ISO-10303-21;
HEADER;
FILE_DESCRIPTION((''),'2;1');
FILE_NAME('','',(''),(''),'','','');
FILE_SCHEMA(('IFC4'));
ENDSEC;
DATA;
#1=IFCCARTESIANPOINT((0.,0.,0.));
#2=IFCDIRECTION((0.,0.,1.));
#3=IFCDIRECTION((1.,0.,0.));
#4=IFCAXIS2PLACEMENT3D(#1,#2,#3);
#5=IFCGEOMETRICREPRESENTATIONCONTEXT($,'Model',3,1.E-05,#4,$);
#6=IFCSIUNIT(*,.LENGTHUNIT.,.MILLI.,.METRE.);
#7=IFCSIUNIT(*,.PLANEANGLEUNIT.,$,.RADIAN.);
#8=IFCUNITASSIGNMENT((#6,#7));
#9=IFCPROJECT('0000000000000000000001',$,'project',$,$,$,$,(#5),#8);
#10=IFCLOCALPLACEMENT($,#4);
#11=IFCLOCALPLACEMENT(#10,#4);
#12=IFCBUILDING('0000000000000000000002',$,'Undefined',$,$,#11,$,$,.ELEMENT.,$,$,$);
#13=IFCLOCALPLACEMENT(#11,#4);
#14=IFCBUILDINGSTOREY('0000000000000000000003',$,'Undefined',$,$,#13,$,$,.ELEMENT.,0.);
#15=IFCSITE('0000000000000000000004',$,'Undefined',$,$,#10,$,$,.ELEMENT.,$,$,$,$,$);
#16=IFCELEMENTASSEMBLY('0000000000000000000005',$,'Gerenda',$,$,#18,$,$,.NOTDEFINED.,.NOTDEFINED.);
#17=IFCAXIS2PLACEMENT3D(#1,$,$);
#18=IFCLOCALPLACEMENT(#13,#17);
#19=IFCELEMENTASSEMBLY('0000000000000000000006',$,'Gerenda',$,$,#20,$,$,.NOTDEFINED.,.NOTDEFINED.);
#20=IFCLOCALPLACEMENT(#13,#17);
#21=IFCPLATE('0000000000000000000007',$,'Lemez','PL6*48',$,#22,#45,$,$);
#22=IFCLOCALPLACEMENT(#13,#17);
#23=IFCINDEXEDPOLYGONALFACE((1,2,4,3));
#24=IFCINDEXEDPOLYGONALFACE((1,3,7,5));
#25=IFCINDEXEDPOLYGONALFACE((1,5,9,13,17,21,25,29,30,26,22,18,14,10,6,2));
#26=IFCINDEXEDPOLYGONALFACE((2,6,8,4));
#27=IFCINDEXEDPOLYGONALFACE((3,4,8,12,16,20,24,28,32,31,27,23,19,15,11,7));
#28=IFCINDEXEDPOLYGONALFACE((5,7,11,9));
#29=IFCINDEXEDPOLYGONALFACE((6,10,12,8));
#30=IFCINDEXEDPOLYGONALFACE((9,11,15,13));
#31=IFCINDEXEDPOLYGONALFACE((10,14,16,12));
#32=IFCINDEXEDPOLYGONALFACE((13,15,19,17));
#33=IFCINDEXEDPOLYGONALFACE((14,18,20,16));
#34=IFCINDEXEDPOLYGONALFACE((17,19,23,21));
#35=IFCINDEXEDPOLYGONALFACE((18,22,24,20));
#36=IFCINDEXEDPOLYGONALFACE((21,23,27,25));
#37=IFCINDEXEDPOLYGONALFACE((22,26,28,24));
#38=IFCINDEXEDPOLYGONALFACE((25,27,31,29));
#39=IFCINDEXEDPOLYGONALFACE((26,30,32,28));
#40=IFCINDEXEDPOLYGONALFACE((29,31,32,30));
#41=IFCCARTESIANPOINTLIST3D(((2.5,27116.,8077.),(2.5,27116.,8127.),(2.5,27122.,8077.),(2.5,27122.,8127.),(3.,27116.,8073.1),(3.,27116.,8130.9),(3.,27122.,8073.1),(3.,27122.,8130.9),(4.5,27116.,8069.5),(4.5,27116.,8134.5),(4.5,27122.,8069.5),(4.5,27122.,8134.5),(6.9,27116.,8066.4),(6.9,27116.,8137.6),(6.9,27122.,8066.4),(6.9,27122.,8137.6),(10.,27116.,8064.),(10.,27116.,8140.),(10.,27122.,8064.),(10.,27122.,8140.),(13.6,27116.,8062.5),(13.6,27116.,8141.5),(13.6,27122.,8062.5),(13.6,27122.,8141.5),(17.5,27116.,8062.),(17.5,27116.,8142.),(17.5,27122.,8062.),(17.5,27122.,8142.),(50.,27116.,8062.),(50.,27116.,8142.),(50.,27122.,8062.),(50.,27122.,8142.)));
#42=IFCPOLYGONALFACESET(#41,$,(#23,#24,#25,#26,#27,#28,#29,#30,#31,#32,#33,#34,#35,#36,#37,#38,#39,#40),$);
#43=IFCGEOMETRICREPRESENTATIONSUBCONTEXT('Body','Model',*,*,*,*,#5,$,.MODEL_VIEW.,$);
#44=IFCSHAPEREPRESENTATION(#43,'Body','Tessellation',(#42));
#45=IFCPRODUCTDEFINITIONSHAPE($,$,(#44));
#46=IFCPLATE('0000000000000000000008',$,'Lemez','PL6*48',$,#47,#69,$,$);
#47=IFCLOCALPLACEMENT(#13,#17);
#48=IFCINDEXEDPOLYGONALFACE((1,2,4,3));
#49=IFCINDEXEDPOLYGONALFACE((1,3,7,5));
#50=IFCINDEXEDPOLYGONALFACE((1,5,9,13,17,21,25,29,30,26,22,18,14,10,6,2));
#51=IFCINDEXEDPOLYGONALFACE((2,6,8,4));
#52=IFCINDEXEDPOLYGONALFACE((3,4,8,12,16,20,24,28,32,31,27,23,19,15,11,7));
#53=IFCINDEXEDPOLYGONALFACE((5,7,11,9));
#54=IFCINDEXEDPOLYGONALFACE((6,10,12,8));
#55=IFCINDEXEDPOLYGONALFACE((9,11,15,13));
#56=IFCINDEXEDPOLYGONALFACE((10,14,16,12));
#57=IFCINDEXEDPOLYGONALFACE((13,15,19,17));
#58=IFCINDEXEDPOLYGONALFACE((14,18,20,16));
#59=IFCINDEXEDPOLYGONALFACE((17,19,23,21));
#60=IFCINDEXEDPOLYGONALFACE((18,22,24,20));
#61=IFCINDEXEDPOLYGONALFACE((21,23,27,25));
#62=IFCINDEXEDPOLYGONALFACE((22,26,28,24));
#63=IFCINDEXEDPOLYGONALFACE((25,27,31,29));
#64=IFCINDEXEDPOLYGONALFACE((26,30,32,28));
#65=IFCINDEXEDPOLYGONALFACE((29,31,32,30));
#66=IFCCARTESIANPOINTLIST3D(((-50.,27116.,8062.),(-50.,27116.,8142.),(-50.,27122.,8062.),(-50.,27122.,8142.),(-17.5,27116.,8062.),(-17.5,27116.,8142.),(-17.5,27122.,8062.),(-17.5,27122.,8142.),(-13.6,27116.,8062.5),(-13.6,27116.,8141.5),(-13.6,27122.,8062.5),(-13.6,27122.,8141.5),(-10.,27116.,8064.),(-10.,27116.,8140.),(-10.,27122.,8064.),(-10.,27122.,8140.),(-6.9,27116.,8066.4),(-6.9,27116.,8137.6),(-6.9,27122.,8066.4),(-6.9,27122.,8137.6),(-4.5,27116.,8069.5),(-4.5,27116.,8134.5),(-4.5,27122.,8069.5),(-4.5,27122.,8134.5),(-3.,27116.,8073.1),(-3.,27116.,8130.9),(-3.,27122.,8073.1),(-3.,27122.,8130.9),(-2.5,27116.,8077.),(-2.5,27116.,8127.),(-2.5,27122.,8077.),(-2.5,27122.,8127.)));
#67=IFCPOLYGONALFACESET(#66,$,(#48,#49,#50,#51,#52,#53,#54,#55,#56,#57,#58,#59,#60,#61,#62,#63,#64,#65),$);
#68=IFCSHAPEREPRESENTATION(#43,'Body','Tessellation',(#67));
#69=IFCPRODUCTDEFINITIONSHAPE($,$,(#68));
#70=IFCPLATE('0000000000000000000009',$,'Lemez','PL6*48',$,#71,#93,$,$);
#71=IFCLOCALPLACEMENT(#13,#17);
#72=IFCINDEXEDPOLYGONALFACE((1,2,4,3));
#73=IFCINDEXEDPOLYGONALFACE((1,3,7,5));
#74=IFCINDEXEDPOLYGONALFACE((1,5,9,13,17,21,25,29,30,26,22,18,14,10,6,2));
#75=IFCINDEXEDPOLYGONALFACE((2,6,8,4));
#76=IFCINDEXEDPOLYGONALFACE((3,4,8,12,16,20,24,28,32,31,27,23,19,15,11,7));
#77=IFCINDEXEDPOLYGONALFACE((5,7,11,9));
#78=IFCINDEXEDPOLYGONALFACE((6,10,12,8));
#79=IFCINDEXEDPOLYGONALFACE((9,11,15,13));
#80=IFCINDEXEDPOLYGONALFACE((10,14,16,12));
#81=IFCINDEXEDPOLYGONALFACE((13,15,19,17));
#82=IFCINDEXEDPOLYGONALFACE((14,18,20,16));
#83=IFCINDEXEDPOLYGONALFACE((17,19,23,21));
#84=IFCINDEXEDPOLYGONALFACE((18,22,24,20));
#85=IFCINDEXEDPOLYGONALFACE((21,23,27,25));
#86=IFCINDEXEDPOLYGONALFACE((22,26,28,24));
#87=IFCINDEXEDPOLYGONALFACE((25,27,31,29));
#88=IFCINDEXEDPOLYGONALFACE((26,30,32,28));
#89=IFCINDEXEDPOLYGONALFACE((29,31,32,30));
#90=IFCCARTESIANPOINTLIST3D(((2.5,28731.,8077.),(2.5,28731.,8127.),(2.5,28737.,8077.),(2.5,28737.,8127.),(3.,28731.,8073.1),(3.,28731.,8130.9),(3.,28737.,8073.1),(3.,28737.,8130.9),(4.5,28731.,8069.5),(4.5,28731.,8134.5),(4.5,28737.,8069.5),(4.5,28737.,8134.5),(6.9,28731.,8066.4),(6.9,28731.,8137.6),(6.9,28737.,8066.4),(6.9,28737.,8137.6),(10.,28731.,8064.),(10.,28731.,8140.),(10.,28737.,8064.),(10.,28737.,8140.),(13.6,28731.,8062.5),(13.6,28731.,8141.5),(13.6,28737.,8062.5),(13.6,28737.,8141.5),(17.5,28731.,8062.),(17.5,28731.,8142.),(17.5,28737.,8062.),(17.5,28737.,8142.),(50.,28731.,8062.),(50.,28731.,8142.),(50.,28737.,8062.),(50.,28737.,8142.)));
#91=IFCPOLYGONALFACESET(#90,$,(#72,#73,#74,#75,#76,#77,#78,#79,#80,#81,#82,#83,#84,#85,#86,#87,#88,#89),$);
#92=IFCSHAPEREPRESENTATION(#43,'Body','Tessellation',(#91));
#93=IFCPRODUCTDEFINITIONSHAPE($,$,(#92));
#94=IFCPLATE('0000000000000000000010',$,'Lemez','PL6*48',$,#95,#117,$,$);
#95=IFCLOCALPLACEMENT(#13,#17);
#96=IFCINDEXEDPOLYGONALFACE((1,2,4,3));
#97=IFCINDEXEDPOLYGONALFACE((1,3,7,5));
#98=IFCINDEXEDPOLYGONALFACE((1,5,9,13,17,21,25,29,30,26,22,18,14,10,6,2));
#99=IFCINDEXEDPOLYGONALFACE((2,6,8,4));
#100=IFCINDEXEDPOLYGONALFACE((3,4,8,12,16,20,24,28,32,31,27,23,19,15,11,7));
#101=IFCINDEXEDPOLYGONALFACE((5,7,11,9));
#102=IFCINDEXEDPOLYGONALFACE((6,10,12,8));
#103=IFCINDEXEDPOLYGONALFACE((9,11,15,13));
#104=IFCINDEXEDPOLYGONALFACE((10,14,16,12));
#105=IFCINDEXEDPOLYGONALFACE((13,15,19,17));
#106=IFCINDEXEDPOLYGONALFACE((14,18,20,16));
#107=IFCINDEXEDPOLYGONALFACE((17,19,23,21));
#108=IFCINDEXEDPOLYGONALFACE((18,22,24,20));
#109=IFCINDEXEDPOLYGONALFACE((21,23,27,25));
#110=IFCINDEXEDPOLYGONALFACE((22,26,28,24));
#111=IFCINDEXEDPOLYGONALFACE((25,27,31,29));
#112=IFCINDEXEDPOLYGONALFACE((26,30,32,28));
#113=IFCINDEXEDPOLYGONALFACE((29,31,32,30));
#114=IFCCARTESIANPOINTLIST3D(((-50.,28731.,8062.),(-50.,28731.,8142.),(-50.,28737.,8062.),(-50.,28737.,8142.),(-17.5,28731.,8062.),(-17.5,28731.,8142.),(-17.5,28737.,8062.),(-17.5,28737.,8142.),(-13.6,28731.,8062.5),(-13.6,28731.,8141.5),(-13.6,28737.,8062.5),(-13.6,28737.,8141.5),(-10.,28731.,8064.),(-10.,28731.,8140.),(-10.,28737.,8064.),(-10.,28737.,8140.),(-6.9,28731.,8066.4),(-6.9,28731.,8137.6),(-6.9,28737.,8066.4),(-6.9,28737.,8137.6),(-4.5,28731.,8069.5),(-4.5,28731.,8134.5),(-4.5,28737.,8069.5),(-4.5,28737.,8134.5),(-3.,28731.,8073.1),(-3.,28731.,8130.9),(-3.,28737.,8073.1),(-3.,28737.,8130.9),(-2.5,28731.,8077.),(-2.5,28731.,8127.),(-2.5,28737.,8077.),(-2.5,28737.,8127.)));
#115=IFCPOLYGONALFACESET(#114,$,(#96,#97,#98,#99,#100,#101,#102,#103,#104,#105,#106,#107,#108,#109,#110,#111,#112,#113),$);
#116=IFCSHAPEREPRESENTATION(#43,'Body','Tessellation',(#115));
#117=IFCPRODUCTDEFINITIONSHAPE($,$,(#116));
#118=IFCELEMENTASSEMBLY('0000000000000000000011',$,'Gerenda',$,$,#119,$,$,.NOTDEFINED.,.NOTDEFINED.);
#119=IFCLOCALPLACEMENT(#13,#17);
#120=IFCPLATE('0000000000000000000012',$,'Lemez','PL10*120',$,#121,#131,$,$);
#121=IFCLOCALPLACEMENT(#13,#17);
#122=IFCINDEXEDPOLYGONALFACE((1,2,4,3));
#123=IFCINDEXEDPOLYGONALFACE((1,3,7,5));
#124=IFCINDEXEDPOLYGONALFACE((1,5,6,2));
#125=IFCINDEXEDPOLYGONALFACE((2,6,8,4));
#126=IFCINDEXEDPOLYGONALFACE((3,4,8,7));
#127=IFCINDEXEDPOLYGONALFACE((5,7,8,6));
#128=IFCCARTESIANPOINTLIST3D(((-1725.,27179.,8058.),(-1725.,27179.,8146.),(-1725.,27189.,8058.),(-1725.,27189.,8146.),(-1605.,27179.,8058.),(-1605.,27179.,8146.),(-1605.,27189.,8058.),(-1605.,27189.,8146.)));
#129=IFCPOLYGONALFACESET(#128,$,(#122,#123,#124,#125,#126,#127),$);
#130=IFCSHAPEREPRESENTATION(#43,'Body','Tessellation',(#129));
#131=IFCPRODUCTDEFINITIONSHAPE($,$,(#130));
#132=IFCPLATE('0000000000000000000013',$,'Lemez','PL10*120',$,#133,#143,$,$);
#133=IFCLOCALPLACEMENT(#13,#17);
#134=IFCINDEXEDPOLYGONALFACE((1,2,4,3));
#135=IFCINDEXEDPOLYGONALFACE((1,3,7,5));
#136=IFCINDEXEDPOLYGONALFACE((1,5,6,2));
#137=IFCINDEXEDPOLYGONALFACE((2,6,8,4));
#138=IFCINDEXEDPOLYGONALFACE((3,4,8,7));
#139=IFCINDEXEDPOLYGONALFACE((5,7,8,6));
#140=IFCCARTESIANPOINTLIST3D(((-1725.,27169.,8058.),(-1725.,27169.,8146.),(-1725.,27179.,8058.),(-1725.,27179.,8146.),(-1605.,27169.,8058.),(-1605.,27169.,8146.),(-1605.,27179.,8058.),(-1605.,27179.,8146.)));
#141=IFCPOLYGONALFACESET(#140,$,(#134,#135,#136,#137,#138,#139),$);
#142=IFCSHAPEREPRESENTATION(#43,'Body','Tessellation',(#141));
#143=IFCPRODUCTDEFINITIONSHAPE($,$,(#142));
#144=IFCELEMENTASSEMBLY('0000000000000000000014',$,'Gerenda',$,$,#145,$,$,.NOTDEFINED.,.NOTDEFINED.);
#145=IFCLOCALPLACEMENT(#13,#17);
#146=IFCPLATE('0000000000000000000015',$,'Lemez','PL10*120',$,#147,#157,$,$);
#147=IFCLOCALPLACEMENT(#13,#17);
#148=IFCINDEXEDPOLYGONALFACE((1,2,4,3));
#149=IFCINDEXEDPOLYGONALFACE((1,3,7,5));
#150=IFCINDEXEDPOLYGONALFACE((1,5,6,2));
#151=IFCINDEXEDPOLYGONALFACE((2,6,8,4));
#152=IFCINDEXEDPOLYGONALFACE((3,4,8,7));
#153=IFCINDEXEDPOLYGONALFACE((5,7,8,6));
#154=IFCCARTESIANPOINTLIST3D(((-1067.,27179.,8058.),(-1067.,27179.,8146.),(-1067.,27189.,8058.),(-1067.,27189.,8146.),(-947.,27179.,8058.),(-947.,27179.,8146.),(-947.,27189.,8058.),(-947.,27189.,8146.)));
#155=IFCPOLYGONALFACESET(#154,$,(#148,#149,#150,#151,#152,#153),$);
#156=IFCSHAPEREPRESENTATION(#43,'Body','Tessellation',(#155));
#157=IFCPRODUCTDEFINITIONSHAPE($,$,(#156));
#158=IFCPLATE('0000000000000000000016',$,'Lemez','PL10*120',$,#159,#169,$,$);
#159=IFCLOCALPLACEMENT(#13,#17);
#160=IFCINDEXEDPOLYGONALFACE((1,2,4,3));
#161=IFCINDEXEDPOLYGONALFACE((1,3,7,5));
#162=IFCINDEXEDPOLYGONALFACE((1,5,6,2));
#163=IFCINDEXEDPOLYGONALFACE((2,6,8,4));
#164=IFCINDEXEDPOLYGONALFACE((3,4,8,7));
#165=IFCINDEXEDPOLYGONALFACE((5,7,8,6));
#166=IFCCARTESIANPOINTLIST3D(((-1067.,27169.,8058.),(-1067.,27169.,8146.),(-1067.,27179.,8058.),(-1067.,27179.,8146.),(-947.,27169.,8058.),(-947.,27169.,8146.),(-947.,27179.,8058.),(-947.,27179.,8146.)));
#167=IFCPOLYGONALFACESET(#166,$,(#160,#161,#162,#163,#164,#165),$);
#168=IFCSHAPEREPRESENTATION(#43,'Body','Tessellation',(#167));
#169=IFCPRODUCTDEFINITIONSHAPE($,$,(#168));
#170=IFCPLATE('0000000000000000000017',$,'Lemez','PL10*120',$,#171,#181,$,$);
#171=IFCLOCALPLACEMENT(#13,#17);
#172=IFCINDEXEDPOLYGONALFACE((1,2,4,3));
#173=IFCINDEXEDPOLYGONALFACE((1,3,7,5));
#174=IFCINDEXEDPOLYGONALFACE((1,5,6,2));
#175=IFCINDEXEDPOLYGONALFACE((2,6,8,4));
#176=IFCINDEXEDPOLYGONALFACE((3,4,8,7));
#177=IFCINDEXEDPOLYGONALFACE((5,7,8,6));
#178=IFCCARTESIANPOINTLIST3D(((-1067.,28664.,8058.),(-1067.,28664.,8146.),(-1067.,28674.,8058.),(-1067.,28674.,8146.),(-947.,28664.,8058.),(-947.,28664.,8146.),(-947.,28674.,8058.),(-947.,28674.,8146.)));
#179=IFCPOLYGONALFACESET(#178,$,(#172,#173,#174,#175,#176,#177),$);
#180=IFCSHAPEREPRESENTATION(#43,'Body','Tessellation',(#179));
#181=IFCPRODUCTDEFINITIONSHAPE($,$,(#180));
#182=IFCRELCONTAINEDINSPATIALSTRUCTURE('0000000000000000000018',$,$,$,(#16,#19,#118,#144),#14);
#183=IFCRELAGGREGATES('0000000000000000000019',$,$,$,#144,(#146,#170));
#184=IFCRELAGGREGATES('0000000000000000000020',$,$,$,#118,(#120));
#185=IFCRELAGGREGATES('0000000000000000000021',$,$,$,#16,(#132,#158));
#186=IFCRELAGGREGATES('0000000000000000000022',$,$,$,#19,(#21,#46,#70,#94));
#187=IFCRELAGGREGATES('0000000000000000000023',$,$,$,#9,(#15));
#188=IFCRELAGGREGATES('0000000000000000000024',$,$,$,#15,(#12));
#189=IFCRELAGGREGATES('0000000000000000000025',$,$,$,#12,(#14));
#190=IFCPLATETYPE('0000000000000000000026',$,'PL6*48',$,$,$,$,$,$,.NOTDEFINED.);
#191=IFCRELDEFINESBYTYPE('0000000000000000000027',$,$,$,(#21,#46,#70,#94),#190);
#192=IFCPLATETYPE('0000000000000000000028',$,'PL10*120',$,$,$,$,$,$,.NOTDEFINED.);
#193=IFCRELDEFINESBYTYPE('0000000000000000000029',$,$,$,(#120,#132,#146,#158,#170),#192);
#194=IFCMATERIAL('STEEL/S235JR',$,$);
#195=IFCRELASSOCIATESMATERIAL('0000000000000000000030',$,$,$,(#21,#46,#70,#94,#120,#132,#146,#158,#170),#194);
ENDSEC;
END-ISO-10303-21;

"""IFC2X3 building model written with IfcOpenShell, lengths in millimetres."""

from ifc_helpers import new_model, si_unit, frame, frame_2d, origin_with_axes, place, context, subcontext, project, spatial, polyline, circle_curve, parameter, trimmed, segment, composite_curve, outline, extrude, material, type_object, element, aggregate, save


model = new_model("IFC2X3")

# Units and contexts
model_context = context("Model", 3, precision=1e-05, world=origin_with_axes())
body_context = subcontext(model_context, "Body", "Model", "MODEL_VIEW")
ifc_project = project(units=[si_unit("LENGTHUNIT", "METRE", prefix="MILLI"), si_unit("PLANEANGLEUNIT", "RADIAN")], contexts=[model_context])

# Site, building, storey
site_placement = place(None, origin_with_axes())
site = spatial("IfcSite", under=ifc_project, at=site_placement, Name="Undefined", CompositionType="ELEMENT")
building_placement = place(site_placement, origin_with_axes())
building = spatial("IfcBuilding", under=site, at=building_placement, Name="Undefined", CompositionType="ELEMENT")
storey_placement = place(building_placement, origin_with_axes())
storey = spatial("IfcBuildingStorey", under=building, at=storey_placement, Name="Undefined", CompositionType="ELEMENT", Elevation=0.0)

# Element assemblies, plates
assembly_1_placement = place(storey_placement, origin_with_axes())
assembly_1 = element("IfcElementAssembly", 1, at=assembly_1_placement, inside=storey, Name="Gerenda", AssemblyPlace="NOTDEFINED", PredefinedType="NOTDEFINED")
ifc_material = material(Name="STEEL/S235JR")
plate_type_1 = type_object("IfcPlateType", Name="PL6*48", PredefinedType="NOTDEFINED")
assembly_2_placement = place(storey_placement, origin_with_axes())
assembly_2 = element("IfcElementAssembly", 2, at=assembly_2_placement, inside=storey, Name="Gerenda", AssemblyPlace="NOTDEFINED", PredefinedType="NOTDEFINED")
plate_1_placement = place(assembly_2_placement, frame((2.5, 27119.0, 8062.0), z_axis=(-0.000003, -1.0, 0.0), x_axis=(1.0, -0.000003, 0.0)))
plate_1 = element("IfcPlate", 3, at=plate_1_placement, type_object=plate_type_1, material=ifc_material, Name="Lemez", Description="PL6*48", context=body_context, shape_type="SweptSolid", body=[
    extrude(outline(composite_curve([segment(trimmed(circle_curve(frame_2d((15.0, 15.0), x_axis=(-1.0, 0.0)), 15.0), [parameter(0.0)], [parameter(1.570796)], True, "PARAMETER"), True, "CONTINUOUS"), segment(polyline([(15.0, 0.0), (47.5, 0.0), (47.5, 80.0), (15.0, 80.0)]), True, "CONTINUOUS"), segment(trimmed(circle_curve(frame_2d((15.0, 65.0), x_axis=(0.0, 1.0)), 15.0), [parameter(0.0)], [parameter(1.570796)], True, "PARAMETER"), True, "CONTINUOUS"), segment(polyline([(0.0, 65.0), (0.0, 15.0)]), True, "CONTINUOUS")], self_intersect=True)), frame((0.0, 0.0, -3.0), z_axis=(0.0, 0.0, 1.0), x_axis=(1.0, 0.0, 0.0)), (0.0, 0.0, 1.0), 6.0),
])
plate_2_placement = place(assembly_2_placement, frame((-2.5, 27119.0, 8062.0), z_axis=(0.000003, 1.0, 0.0), x_axis=(-1.0, 0.000003, 0.0)))
plate_2 = element("IfcPlate", 4, at=plate_2_placement, type_object=plate_type_1, material=ifc_material, Name="Lemez", Description="PL6*48", context=body_context, shape_type="SweptSolid", body=[
    extrude(outline(composite_curve([segment(trimmed(circle_curve(frame_2d((15.0, 15.0), x_axis=(-1.0, 0.0)), 15.0), [parameter(0.0)], [parameter(1.570796)], True, "PARAMETER"), True, "CONTINUOUS"), segment(polyline([(15.0, 0.0), (47.5, 0.0), (47.5, 80.0), (15.0, 80.0)]), True, "CONTINUOUS"), segment(trimmed(circle_curve(frame_2d((15.0, 65.0), x_axis=(0.0, 1.0)), 15.0), [parameter(0.0)], [parameter(1.570796)], True, "PARAMETER"), True, "CONTINUOUS"), segment(polyline([(0.0, 65.0), (0.0, 15.0)]), True, "CONTINUOUS")], self_intersect=True)), frame((0.0, 0.0, -3.0), z_axis=(0.0, 0.0, 1.0), x_axis=(1.0, 0.0, 0.0)), (0.0, 0.0, 1.0), 6.0),
])
plate_3_placement = place(assembly_2_placement, frame((2.5, 28734.0, 8062.0), z_axis=(-0.000003, -1.0, 0.0), x_axis=(1.0, -0.000003, 0.0)))
plate_3 = element("IfcPlate", 5, at=plate_3_placement, type_object=plate_type_1, material=ifc_material, Name="Lemez", Description="PL6*48", context=body_context, shape_type="SweptSolid", body=[
    extrude(outline(composite_curve([segment(trimmed(circle_curve(frame_2d((15.0, 15.0), x_axis=(-1.0, 0.0)), 15.0), [parameter(0.0)], [parameter(1.570796)], True, "PARAMETER"), True, "CONTINUOUS"), segment(polyline([(15.0, 0.0), (47.5, 0.0), (47.5, 80.0), (15.0, 80.0)]), True, "CONTINUOUS"), segment(trimmed(circle_curve(frame_2d((15.0, 65.0), x_axis=(0.0, 1.0)), 15.0), [parameter(0.0)], [parameter(1.570796)], True, "PARAMETER"), True, "CONTINUOUS"), segment(polyline([(0.0, 65.0), (0.0, 15.0)]), True, "CONTINUOUS")], self_intersect=True)), frame((0.0, 0.0, -3.0), z_axis=(0.0, 0.0, 1.0), x_axis=(1.0, 0.0, 0.0)), (0.0, 0.0, 1.0), 6.0),
])
plate_4_placement = place(assembly_2_placement, frame((-2.5, 28734.0, 8062.0), z_axis=(0.000003, 1.0, 0.0), x_axis=(-1.0, 0.000003, 0.0)))
plate_4 = element("IfcPlate", 6, at=plate_4_placement, type_object=plate_type_1, material=ifc_material, Name="Lemez", Description="PL6*48", context=body_context, shape_type="SweptSolid", body=[
    extrude(outline(composite_curve([segment(trimmed(circle_curve(frame_2d((15.0, 15.0), x_axis=(-1.0, 0.0)), 15.0), [parameter(0.0)], [parameter(1.570796)], True, "PARAMETER"), True, "CONTINUOUS"), segment(polyline([(15.0, 0.0), (47.5, 0.0), (47.5, 80.0), (15.0, 80.0)]), True, "CONTINUOUS"), segment(trimmed(circle_curve(frame_2d((15.0, 65.0), x_axis=(0.0, 1.0)), 15.0), [parameter(0.0)], [parameter(1.570796)], True, "PARAMETER"), True, "CONTINUOUS"), segment(polyline([(0.0, 65.0), (0.0, 15.0)]), True, "CONTINUOUS")], self_intersect=True)), frame((0.0, 0.0, -3.0), z_axis=(0.0, 0.0, 1.0), x_axis=(1.0, 0.0, 0.0)), (0.0, 0.0, 1.0), 6.0),
])

# Element assembly, plate
assembly_3_placement = place(storey_placement, origin_with_axes())
assembly_3 = element("IfcElementAssembly", 7, at=assembly_3_placement, inside=storey, Name="Gerenda", AssemblyPlace="NOTDEFINED", PredefinedType="NOTDEFINED")
plate_type_2 = type_object("IfcPlateType", Name="PL10*120", PredefinedType="NOTDEFINED")
plate_5_placement = place(assembly_3_placement, frame((-1665.0, 27184.0, 8058.0), z_axis=(0.000003, 1.0, 0.0), x_axis=(0.0, 0.0, 1.0)))
plate_5 = element("IfcPlate", 8, at=plate_5_placement, type_object=plate_type_2, material=ifc_material, Name="Lemez", Description="PL10*120", context=body_context, shape_type="SweptSolid", body=[
    extrude(outline(polyline([(0.0, -60.0), (0.0, 60.0), (88.0, 60.0), (88.0, -60.0), (0.0, -60.0)])), frame((0.0, 0.0, -5.0), z_axis=(0.0, 0.0, 1.0), x_axis=(1.0, 0.0, 0.0)), (0.0, 0.0, 1.0), 10.0),
])

# Plate
plate_6_placement = place(assembly_1_placement, frame((-1665.0, 27174.0, 8058.0), z_axis=(0.000003, 1.0, 0.0), x_axis=(0.0, 0.0, 1.0)))
plate_6 = element("IfcPlate", 9, at=plate_6_placement, type_object=plate_type_2, material=ifc_material, Name="Lemez", Description="PL10*120", context=body_context, shape_type="SweptSolid", body=[
    extrude(outline(polyline([(0.0, -60.0), (0.0, 60.0), (88.0, 60.0), (88.0, -60.0), (0.0, -60.0)])), frame((0.0, 0.0, -5.0), z_axis=(0.0, 0.0, 1.0), x_axis=(1.0, 0.0, 0.0)), (0.0, 0.0, 1.0), 10.0),
])

# Element assembly, plate
assembly_4_placement = place(storey_placement, origin_with_axes())
assembly_4 = element("IfcElementAssembly", 10, at=assembly_4_placement, inside=storey, Name="Gerenda", AssemblyPlace="NOTDEFINED", PredefinedType="NOTDEFINED")
plate_7_placement = place(assembly_4_placement, frame((-1007.0, 27184.0, 8058.0), z_axis=(0.000003, 1.0, 0.0), x_axis=(0.0, 0.0, 1.0)))
plate_7 = element("IfcPlate", 11, at=plate_7_placement, type_object=plate_type_2, material=ifc_material, Name="Lemez", Description="PL10*120", context=body_context, shape_type="SweptSolid", body=[
    extrude(outline(polyline([(0.0, -60.0), (0.0, 60.0), (88.0, 60.0), (88.0, -60.0), (0.0, -60.0)])), frame((0.0, 0.0, -5.0), z_axis=(0.0, 0.0, 1.0), x_axis=(1.0, 0.0, 0.0)), (0.0, 0.0, 1.0), 10.0),
])

# Plates
plate_8_placement = place(assembly_1_placement, frame((-1007.0, 27174.0, 8058.0), z_axis=(0.000003, 1.0, 0.0), x_axis=(0.0, 0.0, 1.0)))
plate_8 = element("IfcPlate", 12, at=plate_8_placement, type_object=plate_type_2, material=ifc_material, Name="Lemez", Description="PL10*120", context=body_context, shape_type="SweptSolid", body=[
    extrude(outline(polyline([(0.0, -60.0), (0.0, 60.0), (88.0, 60.0), (88.0, -60.0), (0.0, -60.0)])), frame((0.0, 0.0, -5.0), z_axis=(0.0, 0.0, 1.0), x_axis=(1.0, 0.0, 0.0)), (0.0, 0.0, 1.0), 10.0),
])
plate_9_placement = place(assembly_4_placement, frame((-1007.0, 28669.0, 8058.0), z_axis=(-0.000003, -1.0, 0.0), x_axis=(0.0, 0.0, 1.0)))
plate_9 = element("IfcPlate", 13, at=plate_9_placement, type_object=plate_type_2, material=ifc_material, Name="Lemez", Description="PL10*120", context=body_context, shape_type="SweptSolid", body=[
    extrude(outline(polyline([(0.0, -60.0), (0.0, 60.0), (88.0, 60.0), (88.0, -60.0), (0.0, -60.0)])), frame((0.0, 0.0, -5.0), z_axis=(0.0, 0.0, 1.0), x_axis=(1.0, 0.0, 0.0)), (0.0, 0.0, 1.0), 10.0),
])
aggregate(assembly_4, [plate_7, plate_9])
aggregate(assembly_3, [plate_5])
aggregate(assembly_1, [plate_6, plate_8])
aggregate(assembly_2, [plate_1, plate_2, plate_3, plate_4])

save(model, "model.ifc")
